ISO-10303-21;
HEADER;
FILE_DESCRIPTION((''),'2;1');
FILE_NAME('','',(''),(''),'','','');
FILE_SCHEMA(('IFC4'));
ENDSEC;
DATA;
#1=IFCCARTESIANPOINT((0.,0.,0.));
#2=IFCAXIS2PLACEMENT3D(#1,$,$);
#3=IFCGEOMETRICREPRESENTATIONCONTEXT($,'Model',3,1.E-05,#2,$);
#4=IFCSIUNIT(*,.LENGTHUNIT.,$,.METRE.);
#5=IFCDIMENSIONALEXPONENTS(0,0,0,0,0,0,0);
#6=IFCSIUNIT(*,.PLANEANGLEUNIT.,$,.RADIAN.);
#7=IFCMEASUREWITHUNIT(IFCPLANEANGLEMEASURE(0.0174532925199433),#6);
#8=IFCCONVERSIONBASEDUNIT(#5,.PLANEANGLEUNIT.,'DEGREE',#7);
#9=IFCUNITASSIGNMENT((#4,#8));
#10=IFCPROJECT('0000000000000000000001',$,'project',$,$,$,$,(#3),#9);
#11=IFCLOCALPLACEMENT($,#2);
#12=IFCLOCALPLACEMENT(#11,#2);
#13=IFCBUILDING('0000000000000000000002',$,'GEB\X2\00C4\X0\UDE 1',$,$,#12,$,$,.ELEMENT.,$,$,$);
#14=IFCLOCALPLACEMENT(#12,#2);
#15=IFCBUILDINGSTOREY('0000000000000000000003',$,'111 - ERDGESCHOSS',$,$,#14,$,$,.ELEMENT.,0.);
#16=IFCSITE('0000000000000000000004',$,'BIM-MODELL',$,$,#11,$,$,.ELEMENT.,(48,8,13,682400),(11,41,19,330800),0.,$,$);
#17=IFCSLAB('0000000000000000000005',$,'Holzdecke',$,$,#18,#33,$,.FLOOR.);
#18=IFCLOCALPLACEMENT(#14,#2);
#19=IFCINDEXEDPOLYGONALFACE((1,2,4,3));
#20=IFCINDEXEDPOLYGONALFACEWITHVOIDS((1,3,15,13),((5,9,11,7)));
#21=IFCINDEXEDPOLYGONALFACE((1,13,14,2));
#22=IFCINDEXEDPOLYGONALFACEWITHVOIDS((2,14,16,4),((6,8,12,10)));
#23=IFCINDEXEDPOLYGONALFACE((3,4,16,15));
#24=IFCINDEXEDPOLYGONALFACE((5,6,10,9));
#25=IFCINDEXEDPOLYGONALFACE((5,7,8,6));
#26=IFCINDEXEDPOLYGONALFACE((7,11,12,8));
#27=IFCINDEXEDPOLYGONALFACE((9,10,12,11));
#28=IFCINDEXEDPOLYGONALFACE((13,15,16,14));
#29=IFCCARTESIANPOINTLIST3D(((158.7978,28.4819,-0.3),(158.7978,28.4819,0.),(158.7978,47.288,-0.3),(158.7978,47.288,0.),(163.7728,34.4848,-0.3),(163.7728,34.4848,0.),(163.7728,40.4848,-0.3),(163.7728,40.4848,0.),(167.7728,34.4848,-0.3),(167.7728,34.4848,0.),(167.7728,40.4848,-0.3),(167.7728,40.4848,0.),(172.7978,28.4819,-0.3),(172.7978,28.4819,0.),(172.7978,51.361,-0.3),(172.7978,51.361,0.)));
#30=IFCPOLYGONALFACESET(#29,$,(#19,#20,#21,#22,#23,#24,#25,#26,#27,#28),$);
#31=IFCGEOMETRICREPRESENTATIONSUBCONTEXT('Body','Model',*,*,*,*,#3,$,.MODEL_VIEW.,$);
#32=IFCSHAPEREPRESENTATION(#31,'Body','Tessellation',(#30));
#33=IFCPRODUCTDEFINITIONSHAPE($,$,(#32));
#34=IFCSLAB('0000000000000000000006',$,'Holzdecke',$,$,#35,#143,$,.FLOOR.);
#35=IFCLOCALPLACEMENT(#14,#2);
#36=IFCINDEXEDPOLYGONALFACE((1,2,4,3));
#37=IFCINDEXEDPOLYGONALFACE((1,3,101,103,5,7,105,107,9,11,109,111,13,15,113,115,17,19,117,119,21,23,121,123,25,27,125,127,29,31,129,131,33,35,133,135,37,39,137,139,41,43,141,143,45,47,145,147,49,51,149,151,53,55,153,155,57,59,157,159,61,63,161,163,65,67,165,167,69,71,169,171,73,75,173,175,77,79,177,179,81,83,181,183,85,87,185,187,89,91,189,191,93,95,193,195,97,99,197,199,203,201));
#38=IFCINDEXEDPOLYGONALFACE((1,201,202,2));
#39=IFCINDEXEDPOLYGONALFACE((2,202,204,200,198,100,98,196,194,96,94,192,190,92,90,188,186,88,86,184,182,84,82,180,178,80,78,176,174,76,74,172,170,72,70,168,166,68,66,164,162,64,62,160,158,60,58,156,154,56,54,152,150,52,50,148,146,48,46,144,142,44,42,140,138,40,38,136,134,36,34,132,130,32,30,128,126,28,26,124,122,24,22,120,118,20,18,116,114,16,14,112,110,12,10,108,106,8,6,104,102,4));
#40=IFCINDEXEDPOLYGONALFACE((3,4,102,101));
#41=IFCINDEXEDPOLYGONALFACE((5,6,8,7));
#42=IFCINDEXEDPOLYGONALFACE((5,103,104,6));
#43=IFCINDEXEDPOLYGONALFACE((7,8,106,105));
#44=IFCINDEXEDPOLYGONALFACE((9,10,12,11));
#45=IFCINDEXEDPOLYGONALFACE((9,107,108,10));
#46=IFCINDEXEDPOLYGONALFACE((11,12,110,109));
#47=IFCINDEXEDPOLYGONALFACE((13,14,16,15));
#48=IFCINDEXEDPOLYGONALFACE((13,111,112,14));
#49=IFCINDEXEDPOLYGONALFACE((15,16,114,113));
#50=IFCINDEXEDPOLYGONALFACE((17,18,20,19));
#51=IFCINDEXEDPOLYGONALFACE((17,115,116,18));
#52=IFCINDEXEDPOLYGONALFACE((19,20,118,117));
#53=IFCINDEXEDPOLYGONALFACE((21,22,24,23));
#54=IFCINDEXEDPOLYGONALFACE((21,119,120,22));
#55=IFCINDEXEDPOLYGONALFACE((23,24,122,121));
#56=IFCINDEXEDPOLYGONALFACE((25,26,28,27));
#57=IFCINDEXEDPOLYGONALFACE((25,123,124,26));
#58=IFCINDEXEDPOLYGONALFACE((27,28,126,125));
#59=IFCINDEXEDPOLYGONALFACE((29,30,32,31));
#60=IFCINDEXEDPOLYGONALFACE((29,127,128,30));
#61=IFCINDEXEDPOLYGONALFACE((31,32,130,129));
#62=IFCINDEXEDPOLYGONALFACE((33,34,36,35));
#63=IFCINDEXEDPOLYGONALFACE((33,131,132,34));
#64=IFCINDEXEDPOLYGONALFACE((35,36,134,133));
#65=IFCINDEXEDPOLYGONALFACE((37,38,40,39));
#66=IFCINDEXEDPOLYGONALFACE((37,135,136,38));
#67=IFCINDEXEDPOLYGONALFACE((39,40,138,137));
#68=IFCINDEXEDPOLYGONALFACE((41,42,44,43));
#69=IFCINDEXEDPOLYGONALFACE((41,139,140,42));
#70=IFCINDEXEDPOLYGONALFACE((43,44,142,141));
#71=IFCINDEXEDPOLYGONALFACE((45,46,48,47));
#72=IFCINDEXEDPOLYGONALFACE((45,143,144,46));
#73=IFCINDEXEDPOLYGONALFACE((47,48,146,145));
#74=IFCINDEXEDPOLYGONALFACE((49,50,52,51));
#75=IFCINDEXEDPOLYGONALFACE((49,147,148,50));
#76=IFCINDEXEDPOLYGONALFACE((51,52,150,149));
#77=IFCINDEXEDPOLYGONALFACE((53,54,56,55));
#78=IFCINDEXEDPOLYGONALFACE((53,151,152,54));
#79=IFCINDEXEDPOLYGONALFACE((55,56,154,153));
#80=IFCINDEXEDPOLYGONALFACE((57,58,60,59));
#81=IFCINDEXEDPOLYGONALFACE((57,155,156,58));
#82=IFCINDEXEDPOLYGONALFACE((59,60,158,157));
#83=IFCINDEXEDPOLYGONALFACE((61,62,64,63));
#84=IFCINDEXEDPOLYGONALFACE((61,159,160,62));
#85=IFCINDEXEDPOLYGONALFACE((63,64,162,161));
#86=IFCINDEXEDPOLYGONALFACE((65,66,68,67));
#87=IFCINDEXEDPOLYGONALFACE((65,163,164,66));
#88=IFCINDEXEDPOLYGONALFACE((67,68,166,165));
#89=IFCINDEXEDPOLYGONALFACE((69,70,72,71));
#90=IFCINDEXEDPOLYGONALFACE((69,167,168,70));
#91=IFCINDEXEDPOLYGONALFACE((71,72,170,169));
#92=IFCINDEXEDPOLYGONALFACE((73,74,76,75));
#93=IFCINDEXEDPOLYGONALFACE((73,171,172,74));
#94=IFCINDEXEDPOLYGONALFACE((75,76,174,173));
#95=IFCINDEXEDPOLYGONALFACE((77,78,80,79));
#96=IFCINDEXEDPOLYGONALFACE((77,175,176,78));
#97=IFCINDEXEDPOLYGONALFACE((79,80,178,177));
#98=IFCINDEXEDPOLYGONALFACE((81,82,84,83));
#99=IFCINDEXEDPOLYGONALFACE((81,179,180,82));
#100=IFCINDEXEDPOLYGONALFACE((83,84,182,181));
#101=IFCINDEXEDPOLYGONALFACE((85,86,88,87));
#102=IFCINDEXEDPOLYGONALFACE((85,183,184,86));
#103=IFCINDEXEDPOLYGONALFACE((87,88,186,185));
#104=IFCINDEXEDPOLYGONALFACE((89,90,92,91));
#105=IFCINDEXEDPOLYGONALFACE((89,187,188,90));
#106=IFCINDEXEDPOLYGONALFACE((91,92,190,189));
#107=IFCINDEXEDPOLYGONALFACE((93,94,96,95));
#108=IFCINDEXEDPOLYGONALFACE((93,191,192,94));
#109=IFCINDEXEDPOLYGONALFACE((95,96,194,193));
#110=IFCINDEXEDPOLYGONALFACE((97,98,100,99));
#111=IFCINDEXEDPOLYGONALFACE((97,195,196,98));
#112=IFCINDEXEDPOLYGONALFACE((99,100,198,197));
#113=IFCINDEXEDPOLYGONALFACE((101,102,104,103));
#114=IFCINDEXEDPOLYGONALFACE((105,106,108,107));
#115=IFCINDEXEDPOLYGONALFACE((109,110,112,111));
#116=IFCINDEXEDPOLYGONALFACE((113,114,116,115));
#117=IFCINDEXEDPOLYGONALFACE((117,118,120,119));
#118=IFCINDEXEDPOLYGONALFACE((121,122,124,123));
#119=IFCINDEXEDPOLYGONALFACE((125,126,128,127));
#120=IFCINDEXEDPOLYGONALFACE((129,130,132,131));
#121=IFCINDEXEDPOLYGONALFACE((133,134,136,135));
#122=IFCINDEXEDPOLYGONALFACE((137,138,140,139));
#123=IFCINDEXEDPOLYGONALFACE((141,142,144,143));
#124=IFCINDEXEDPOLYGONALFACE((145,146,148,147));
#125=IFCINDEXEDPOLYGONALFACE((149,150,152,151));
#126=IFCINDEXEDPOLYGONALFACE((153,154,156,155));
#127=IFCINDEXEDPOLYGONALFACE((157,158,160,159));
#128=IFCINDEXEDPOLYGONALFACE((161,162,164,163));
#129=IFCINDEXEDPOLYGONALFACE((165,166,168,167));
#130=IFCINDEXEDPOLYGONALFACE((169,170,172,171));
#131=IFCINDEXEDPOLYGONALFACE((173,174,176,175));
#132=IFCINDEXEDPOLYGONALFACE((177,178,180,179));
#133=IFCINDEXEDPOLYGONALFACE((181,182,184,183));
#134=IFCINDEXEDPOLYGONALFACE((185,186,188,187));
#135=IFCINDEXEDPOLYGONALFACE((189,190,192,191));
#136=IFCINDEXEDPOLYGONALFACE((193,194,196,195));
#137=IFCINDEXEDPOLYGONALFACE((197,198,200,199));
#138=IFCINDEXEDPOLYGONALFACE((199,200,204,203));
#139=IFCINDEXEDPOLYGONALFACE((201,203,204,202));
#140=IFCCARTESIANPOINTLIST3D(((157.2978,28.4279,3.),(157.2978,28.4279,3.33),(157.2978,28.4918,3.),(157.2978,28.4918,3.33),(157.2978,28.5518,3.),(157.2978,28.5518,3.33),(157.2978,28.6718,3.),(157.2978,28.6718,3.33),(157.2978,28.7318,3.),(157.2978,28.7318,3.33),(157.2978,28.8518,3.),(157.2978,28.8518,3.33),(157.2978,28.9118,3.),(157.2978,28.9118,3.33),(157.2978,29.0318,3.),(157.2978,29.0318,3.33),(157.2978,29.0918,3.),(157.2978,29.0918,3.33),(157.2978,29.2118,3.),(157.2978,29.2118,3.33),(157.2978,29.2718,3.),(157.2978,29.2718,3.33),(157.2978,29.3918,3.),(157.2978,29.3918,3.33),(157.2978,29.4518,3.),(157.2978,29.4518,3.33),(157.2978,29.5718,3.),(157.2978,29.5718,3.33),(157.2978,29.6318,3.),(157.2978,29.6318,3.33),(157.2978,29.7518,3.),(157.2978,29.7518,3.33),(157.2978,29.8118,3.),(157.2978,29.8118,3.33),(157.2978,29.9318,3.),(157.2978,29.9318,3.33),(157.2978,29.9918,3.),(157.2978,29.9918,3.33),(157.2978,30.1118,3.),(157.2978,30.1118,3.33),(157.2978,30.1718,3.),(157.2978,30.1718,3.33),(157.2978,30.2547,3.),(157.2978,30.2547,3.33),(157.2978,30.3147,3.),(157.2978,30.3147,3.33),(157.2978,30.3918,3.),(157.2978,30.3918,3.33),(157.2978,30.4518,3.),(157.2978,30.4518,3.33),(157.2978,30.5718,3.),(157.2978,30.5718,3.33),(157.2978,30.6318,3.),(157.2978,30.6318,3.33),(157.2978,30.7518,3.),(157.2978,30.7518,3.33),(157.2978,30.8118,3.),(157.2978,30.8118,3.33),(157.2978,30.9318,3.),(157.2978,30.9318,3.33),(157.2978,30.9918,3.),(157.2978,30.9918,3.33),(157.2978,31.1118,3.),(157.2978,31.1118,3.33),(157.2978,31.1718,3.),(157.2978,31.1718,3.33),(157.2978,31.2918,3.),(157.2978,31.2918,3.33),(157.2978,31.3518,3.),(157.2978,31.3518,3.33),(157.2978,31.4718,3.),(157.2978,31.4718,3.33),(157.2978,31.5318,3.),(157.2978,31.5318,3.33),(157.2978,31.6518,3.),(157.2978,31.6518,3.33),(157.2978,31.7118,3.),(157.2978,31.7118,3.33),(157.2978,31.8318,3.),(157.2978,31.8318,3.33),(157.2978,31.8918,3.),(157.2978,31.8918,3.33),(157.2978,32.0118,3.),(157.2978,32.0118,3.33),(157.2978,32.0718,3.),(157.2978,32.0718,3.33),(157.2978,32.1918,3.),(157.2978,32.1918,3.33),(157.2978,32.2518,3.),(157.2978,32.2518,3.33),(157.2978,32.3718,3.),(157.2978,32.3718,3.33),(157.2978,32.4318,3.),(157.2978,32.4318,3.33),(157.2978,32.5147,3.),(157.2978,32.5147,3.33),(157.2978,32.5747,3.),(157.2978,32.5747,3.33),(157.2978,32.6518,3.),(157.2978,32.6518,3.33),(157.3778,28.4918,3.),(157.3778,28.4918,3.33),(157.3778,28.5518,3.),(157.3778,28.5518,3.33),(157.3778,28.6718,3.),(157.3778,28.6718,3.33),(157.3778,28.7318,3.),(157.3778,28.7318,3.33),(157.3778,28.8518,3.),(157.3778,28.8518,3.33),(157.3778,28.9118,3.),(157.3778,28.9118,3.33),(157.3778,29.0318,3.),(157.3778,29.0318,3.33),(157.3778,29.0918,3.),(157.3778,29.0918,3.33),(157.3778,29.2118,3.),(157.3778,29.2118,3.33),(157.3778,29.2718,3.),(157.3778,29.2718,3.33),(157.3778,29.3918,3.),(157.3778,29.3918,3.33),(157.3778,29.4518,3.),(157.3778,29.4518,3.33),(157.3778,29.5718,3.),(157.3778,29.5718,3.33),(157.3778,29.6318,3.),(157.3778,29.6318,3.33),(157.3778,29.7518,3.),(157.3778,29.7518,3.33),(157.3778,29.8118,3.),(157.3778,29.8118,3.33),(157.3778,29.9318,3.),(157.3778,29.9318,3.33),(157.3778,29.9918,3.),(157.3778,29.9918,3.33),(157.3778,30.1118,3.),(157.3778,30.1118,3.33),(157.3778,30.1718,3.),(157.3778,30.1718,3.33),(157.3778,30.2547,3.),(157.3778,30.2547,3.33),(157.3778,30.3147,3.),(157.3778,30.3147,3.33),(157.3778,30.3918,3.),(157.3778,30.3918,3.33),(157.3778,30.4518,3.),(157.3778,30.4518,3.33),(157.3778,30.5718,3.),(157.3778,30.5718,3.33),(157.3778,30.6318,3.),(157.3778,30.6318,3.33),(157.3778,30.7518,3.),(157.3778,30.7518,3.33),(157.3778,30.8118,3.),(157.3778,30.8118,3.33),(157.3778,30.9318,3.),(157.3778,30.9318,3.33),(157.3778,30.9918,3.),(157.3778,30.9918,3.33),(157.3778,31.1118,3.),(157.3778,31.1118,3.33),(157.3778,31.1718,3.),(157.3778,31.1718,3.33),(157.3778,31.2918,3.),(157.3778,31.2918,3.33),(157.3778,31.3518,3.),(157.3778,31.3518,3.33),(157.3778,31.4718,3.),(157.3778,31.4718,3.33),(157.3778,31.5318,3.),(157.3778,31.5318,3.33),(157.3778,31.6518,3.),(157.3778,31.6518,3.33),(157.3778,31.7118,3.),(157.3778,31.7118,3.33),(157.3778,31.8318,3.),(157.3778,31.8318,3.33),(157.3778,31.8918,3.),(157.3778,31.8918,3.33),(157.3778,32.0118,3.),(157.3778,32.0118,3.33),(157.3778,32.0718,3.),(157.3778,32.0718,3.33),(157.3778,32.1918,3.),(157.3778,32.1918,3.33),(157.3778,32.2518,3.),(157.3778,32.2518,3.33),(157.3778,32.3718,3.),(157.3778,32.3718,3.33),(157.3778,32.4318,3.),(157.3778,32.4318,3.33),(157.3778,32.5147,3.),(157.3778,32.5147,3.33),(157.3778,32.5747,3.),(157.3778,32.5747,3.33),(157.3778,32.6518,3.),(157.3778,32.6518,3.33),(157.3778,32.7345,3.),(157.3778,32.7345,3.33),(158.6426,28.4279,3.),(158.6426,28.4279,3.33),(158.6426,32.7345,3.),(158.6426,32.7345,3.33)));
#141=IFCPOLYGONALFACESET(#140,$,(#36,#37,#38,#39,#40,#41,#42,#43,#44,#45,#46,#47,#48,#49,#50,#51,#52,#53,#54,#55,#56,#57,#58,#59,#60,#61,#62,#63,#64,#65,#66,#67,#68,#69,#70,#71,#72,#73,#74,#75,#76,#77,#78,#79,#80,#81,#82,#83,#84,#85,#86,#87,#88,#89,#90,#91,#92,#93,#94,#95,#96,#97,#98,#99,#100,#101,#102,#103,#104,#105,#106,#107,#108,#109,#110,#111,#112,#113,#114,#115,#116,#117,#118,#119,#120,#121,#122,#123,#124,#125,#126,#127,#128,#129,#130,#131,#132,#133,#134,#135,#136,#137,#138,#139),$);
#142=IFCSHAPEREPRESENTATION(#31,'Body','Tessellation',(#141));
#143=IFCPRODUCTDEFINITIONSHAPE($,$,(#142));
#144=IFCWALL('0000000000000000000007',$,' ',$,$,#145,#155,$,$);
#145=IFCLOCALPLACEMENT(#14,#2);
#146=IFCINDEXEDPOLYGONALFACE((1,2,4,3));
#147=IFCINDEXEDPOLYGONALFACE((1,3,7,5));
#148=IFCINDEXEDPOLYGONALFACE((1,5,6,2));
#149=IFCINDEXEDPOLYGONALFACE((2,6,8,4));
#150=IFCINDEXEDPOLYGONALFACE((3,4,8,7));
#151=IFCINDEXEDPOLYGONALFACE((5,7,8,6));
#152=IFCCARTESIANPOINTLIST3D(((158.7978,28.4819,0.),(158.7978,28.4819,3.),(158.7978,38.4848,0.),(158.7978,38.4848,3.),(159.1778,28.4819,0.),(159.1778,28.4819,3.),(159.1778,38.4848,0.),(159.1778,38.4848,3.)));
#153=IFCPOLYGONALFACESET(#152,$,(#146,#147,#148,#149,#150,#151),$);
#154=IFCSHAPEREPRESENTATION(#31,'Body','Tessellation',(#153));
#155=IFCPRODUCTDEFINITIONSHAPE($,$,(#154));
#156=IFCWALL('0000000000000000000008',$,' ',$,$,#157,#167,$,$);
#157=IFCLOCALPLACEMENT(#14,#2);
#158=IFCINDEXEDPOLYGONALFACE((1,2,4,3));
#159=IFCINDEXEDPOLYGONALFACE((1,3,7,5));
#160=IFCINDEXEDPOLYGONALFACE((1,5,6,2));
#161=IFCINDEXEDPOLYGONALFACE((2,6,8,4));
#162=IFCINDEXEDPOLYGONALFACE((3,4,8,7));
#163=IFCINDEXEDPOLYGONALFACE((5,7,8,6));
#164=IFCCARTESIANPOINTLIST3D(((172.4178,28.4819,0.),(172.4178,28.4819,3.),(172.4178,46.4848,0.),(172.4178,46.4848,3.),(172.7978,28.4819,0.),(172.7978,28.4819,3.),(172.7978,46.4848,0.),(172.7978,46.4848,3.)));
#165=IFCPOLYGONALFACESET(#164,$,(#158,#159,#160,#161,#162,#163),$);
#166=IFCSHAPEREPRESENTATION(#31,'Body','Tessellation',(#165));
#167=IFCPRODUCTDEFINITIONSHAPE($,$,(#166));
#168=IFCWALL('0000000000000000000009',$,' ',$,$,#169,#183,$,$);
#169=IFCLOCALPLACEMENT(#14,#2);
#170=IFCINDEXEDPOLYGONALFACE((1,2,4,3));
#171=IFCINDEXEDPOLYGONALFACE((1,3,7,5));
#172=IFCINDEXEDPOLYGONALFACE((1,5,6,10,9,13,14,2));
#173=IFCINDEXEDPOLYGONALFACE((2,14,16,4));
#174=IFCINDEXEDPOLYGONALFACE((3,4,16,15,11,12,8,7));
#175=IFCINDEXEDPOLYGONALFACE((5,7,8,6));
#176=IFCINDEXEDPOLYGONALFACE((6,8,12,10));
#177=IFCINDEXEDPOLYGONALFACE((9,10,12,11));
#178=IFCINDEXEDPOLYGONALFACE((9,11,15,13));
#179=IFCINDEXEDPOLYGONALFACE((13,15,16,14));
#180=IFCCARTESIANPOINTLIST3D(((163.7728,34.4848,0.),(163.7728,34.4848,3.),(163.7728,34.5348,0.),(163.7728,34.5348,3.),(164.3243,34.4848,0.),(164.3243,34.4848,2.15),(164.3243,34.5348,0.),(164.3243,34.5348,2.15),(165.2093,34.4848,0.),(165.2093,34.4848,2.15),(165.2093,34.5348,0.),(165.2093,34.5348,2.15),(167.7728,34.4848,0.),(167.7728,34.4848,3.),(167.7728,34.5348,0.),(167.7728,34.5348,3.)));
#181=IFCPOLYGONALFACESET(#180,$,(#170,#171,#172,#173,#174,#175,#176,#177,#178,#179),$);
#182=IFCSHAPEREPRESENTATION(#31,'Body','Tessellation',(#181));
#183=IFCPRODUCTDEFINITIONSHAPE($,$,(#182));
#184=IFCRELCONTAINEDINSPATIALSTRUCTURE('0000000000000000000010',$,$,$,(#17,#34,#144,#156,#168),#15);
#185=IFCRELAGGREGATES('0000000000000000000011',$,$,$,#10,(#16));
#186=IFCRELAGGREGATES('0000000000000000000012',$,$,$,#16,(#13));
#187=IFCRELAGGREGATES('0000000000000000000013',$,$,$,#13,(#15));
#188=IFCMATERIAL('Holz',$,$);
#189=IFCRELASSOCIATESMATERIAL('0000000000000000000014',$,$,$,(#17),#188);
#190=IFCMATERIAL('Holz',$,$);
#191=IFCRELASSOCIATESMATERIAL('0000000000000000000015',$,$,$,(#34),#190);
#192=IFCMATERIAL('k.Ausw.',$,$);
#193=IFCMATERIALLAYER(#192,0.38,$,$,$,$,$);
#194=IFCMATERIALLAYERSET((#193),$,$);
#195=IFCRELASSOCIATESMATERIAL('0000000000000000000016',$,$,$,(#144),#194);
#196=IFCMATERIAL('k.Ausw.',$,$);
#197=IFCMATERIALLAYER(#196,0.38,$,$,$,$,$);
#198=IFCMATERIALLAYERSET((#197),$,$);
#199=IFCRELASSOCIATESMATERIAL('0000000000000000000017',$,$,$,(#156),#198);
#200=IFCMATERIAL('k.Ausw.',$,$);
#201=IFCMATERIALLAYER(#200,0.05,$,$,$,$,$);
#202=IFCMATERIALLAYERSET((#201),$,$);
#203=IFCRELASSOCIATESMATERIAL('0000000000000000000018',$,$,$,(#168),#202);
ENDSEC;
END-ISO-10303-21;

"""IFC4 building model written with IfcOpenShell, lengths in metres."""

from ifc_helpers import new_model, entity, si_unit, converted_unit, frame, frame_2d, origin, origin_with_axes, place, context, subcontext, project, spatial, polyline, rectangle, outline, extrude, material, layer, layer_set, layer_usage, element, save


model = new_model("IFC4")

# Units and contexts
model_context = context("Model", 3, precision=1e-05, world=origin())
body_context = subcontext(model_context, "Body", "Model", "MODEL_VIEW")
ifc_project = project(units=[si_unit("LENGTHUNIT", "METRE"), converted_unit("PLANEANGLEUNIT", "DEGREE", entity("IfcPlaneAngleMeasure", 0.0174532925199433), si_unit("PLANEANGLEUNIT", "RADIAN"), dimensions=[0, 0, 0, 0, 0, 0, 0])], contexts=[model_context])

# Site, building, storey
site_placement = place(None, origin())
site = spatial("IfcSite", under=ifc_project, at=site_placement, Name="BIM-MODELL", CompositionType="ELEMENT", RefLatitude=(48, 8, 13, 682400), RefLongitude=(11, 41, 19, 330800), RefElevation=0.0)
building_placement = place(site_placement, origin())
building = spatial("IfcBuilding", under=site, at=building_placement, Name="GEBÄUDE 1", CompositionType="ELEMENT")
storey_placement = place(building_placement, origin())
storey = spatial("IfcBuildingStorey", under=building, at=storey_placement, Name="111 - ERDGESCHOSS", CompositionType="ELEMENT", Elevation=0.0)

# Slabs
ifc_material_1 = material(Name="Holz")
slab_1_placement = place(storey_placement, frame((158.7978, 28.4819, -0.3)))
element("IfcSlab", 1, at=slab_1_placement, inside=storey, material=ifc_material_1, Name="Holzdecke", PredefinedType="FLOOR", context=body_context, shape_type="SweptSolid", body=[
    extrude(outline(polyline([(0.0, 0.0), (14.0, 0.0), (14.0, 22.8791), (0.0, 18.8061), (0.0, 0.0)]), holes=[polyline([(8.975, 12.0029), (8.975, 6.0029), (4.975, 6.0029), (4.975, 12.0029), (8.975, 12.0029)])]), origin_with_axes(), (0.0, 0.0, 1.0), 0.3),
])
ifc_material_2 = material(Name="Holz")
slab_2_placement = place(storey_placement, frame((157.2978, 28.4279, 3.0)))
element("IfcSlab", 2, at=slab_2_placement, inside=storey, material=ifc_material_2, Name="Holzdecke", PredefinedType="FLOOR", context=body_context, shape_type="SweptSolid", body=[
    extrude(outline(polyline([(0.08, 4.2239), (0.0, 4.2239), (0.0, 4.1468), (0.08, 4.1468), (0.08, 4.0868), (0.0, 4.0868), (0.0, 4.0039), (0.08, 4.0039), (0.08, 3.9439), (0.0, 3.9439), (0.0, 3.8239), (0.08, 3.8239), (0.08, 3.7639), (0.0, 3.7639), (0.0, 3.6439), (0.08, 3.6439), (0.08, 3.5839), (0.0, 3.5839), (0.0, 3.4639), (0.08, 3.4639), (0.08, 3.4039), (0.0, 3.4039), (0.0, 3.2839), (0.08, 3.2839), (0.08, 3.2239), (0.0, 3.2239), (0.0, 3.1039), (0.08, 3.1039), (0.08, 3.0439), (0.0, 3.0439), (0.0, 2.9239), (0.08, 2.9239), (0.08, 2.8639), (0.0, 2.8639), (0.0, 2.7439), (0.08, 2.7439), (0.08, 2.6839), (0.0, 2.6839), (0.0, 2.5639), (0.08, 2.5639), (0.08, 2.5039), (0.0, 2.5039), (0.0, 2.3839), (0.08, 2.3839), (0.08, 2.3239), (0.0, 2.3239), (0.0, 2.2039), (0.08, 2.2039), (0.08, 2.1439), (0.0, 2.1439), (0.0, 2.0239), (0.08, 2.0239), (0.08, 1.9639), (0.0, 1.9639), (0.0, 1.8868), (0.08, 1.8868), (0.08, 1.8268), (0.0, 1.8268), (0.0, 1.7439), (0.08, 1.7439), (0.08, 1.6839), (0.0, 1.6839), (0.0, 1.5639), (0.08, 1.5639), (0.08, 1.5039), (0.0, 1.5039), (0.0, 1.3839), (0.08, 1.3839), (0.08, 1.3239), (0.0, 1.3239), (0.0, 1.2039), (0.08, 1.2039), (0.08, 1.1439), (0.0, 1.1439), (0.0, 1.0239), (0.08, 1.0239), (0.08, 0.9639), (0.0, 0.9639), (0.0, 0.8439), (0.08, 0.8439), (0.08, 0.7839), (0.0, 0.7839), (0.0, 0.6639), (0.08, 0.6639), (0.08, 0.6039), (0.0, 0.6039), (0.0, 0.4839), (0.08, 0.4839), (0.08, 0.4239), (0.0, 0.4239), (0.0, 0.3039), (0.08, 0.3039), (0.08, 0.2439), (0.0, 0.2439), (0.0, 0.1239), (0.08, 0.1239), (0.08, 0.0639), (0.0, 0.0639), (0.0, 0.0), (1.3448, 0.0), (1.3448, 4.3065), (0.08, 4.3065), (0.08, 4.2239)])), origin_with_axes(), (0.0, 0.0, 1.0), 0.33),
])

# Walls
ifc_material_3 = material(Name="k.Ausw.")
ifc_layer_1 = layer(ifc_material_3, 0.38)
ifc_layer_set_1 = layer_set([ifc_layer_1])
ifc_layer_usage_1 = layer_usage(ifc_layer_set_1, "AXIS2", "POSITIVE", 0.0)
wall_1_placement = place(storey_placement, frame((158.7978, 38.4848, 0.0), z_axis=(0.0, 0.0, 1.0), x_axis=(0.0, -1.0, 0.0)))
element("IfcWall", 3, at=wall_1_placement, inside=storey, material=ifc_layer_usage_1, Name=" ", context=body_context, shape_type="SweptSolid", body=[
    extrude(rectangle(XDim=10.0029, YDim=0.38, at=frame_2d((5.0014, 0.19), x_axis=(1.0, 0.0))), origin_with_axes(), (0.0, 0.0, 1.0), 3.0),
])
ifc_material_4 = material(Name="k.Ausw.")
ifc_layer_2 = layer(ifc_material_4, 0.38)
ifc_layer_set_2 = layer_set([ifc_layer_2])
ifc_layer_usage_2 = layer_usage(ifc_layer_set_2, "AXIS2", "POSITIVE", 0.0)
wall_2_placement = place(storey_placement, frame((172.7978, 28.4819, 0.0), z_axis=(0.0, 0.0, 1.0), x_axis=(0.0, 1.0, 0.0)))
element("IfcWall", 4, at=wall_2_placement, inside=storey, material=ifc_layer_usage_2, Name=" ", context=body_context, shape_type="SweptSolid", body=[
    extrude(rectangle(XDim=18.0029, YDim=0.38, at=frame_2d((9.0014, 0.19), x_axis=(1.0, 0.0))), origin_with_axes(), (0.0, 0.0, 1.0), 3.0),
])

# Wall, opening
ifc_material_5 = material(Name="k.Ausw.")
ifc_layer_3 = layer(ifc_material_5, 0.05)
ifc_layer_set_3 = layer_set([ifc_layer_3])
ifc_layer_usage_3 = layer_usage(ifc_layer_set_3, "AXIS2", "POSITIVE", 0.0)
wall_3_placement = place(storey_placement, frame((163.7728, 34.4848, 0.0), z_axis=(0.0, 0.0, 1.0), x_axis=(1.0, 0.0, 0.0)))
wall_3 = element("IfcWall", 5, at=wall_3_placement, inside=storey, material=ifc_layer_usage_3, Name=" ", context=body_context, shape_type="SweptSolid", body=[
    extrude(rectangle(XDim=4.0, YDim=0.05, at=frame_2d((2.0, 0.025), x_axis=(1.0, 0.0))), origin_with_axes(), (0.0, 0.0, 1.0), 3.0),
])
opening_1_placement = place(wall_3_placement, frame((1.4366, 0.05, -0.15), z_axis=(0.0, -1.0, 0.0), x_axis=(0.0, 0.0, 1.0)))
element("IfcOpeningElement", 6, at=opening_1_placement, cuts=wall_3, ObjectType="Opening", context=body_context, shape_type="SweptSolid", body=[
    extrude(outline(polyline([(0.0, 0.885), (2.3, 0.885), (2.3, 0.0), (0.0, 0.0), (0.0, 0.885)])), origin_with_axes(), (0.0, 0.0, 1.0), 0.05),
])

save(model, "model.ifc")
